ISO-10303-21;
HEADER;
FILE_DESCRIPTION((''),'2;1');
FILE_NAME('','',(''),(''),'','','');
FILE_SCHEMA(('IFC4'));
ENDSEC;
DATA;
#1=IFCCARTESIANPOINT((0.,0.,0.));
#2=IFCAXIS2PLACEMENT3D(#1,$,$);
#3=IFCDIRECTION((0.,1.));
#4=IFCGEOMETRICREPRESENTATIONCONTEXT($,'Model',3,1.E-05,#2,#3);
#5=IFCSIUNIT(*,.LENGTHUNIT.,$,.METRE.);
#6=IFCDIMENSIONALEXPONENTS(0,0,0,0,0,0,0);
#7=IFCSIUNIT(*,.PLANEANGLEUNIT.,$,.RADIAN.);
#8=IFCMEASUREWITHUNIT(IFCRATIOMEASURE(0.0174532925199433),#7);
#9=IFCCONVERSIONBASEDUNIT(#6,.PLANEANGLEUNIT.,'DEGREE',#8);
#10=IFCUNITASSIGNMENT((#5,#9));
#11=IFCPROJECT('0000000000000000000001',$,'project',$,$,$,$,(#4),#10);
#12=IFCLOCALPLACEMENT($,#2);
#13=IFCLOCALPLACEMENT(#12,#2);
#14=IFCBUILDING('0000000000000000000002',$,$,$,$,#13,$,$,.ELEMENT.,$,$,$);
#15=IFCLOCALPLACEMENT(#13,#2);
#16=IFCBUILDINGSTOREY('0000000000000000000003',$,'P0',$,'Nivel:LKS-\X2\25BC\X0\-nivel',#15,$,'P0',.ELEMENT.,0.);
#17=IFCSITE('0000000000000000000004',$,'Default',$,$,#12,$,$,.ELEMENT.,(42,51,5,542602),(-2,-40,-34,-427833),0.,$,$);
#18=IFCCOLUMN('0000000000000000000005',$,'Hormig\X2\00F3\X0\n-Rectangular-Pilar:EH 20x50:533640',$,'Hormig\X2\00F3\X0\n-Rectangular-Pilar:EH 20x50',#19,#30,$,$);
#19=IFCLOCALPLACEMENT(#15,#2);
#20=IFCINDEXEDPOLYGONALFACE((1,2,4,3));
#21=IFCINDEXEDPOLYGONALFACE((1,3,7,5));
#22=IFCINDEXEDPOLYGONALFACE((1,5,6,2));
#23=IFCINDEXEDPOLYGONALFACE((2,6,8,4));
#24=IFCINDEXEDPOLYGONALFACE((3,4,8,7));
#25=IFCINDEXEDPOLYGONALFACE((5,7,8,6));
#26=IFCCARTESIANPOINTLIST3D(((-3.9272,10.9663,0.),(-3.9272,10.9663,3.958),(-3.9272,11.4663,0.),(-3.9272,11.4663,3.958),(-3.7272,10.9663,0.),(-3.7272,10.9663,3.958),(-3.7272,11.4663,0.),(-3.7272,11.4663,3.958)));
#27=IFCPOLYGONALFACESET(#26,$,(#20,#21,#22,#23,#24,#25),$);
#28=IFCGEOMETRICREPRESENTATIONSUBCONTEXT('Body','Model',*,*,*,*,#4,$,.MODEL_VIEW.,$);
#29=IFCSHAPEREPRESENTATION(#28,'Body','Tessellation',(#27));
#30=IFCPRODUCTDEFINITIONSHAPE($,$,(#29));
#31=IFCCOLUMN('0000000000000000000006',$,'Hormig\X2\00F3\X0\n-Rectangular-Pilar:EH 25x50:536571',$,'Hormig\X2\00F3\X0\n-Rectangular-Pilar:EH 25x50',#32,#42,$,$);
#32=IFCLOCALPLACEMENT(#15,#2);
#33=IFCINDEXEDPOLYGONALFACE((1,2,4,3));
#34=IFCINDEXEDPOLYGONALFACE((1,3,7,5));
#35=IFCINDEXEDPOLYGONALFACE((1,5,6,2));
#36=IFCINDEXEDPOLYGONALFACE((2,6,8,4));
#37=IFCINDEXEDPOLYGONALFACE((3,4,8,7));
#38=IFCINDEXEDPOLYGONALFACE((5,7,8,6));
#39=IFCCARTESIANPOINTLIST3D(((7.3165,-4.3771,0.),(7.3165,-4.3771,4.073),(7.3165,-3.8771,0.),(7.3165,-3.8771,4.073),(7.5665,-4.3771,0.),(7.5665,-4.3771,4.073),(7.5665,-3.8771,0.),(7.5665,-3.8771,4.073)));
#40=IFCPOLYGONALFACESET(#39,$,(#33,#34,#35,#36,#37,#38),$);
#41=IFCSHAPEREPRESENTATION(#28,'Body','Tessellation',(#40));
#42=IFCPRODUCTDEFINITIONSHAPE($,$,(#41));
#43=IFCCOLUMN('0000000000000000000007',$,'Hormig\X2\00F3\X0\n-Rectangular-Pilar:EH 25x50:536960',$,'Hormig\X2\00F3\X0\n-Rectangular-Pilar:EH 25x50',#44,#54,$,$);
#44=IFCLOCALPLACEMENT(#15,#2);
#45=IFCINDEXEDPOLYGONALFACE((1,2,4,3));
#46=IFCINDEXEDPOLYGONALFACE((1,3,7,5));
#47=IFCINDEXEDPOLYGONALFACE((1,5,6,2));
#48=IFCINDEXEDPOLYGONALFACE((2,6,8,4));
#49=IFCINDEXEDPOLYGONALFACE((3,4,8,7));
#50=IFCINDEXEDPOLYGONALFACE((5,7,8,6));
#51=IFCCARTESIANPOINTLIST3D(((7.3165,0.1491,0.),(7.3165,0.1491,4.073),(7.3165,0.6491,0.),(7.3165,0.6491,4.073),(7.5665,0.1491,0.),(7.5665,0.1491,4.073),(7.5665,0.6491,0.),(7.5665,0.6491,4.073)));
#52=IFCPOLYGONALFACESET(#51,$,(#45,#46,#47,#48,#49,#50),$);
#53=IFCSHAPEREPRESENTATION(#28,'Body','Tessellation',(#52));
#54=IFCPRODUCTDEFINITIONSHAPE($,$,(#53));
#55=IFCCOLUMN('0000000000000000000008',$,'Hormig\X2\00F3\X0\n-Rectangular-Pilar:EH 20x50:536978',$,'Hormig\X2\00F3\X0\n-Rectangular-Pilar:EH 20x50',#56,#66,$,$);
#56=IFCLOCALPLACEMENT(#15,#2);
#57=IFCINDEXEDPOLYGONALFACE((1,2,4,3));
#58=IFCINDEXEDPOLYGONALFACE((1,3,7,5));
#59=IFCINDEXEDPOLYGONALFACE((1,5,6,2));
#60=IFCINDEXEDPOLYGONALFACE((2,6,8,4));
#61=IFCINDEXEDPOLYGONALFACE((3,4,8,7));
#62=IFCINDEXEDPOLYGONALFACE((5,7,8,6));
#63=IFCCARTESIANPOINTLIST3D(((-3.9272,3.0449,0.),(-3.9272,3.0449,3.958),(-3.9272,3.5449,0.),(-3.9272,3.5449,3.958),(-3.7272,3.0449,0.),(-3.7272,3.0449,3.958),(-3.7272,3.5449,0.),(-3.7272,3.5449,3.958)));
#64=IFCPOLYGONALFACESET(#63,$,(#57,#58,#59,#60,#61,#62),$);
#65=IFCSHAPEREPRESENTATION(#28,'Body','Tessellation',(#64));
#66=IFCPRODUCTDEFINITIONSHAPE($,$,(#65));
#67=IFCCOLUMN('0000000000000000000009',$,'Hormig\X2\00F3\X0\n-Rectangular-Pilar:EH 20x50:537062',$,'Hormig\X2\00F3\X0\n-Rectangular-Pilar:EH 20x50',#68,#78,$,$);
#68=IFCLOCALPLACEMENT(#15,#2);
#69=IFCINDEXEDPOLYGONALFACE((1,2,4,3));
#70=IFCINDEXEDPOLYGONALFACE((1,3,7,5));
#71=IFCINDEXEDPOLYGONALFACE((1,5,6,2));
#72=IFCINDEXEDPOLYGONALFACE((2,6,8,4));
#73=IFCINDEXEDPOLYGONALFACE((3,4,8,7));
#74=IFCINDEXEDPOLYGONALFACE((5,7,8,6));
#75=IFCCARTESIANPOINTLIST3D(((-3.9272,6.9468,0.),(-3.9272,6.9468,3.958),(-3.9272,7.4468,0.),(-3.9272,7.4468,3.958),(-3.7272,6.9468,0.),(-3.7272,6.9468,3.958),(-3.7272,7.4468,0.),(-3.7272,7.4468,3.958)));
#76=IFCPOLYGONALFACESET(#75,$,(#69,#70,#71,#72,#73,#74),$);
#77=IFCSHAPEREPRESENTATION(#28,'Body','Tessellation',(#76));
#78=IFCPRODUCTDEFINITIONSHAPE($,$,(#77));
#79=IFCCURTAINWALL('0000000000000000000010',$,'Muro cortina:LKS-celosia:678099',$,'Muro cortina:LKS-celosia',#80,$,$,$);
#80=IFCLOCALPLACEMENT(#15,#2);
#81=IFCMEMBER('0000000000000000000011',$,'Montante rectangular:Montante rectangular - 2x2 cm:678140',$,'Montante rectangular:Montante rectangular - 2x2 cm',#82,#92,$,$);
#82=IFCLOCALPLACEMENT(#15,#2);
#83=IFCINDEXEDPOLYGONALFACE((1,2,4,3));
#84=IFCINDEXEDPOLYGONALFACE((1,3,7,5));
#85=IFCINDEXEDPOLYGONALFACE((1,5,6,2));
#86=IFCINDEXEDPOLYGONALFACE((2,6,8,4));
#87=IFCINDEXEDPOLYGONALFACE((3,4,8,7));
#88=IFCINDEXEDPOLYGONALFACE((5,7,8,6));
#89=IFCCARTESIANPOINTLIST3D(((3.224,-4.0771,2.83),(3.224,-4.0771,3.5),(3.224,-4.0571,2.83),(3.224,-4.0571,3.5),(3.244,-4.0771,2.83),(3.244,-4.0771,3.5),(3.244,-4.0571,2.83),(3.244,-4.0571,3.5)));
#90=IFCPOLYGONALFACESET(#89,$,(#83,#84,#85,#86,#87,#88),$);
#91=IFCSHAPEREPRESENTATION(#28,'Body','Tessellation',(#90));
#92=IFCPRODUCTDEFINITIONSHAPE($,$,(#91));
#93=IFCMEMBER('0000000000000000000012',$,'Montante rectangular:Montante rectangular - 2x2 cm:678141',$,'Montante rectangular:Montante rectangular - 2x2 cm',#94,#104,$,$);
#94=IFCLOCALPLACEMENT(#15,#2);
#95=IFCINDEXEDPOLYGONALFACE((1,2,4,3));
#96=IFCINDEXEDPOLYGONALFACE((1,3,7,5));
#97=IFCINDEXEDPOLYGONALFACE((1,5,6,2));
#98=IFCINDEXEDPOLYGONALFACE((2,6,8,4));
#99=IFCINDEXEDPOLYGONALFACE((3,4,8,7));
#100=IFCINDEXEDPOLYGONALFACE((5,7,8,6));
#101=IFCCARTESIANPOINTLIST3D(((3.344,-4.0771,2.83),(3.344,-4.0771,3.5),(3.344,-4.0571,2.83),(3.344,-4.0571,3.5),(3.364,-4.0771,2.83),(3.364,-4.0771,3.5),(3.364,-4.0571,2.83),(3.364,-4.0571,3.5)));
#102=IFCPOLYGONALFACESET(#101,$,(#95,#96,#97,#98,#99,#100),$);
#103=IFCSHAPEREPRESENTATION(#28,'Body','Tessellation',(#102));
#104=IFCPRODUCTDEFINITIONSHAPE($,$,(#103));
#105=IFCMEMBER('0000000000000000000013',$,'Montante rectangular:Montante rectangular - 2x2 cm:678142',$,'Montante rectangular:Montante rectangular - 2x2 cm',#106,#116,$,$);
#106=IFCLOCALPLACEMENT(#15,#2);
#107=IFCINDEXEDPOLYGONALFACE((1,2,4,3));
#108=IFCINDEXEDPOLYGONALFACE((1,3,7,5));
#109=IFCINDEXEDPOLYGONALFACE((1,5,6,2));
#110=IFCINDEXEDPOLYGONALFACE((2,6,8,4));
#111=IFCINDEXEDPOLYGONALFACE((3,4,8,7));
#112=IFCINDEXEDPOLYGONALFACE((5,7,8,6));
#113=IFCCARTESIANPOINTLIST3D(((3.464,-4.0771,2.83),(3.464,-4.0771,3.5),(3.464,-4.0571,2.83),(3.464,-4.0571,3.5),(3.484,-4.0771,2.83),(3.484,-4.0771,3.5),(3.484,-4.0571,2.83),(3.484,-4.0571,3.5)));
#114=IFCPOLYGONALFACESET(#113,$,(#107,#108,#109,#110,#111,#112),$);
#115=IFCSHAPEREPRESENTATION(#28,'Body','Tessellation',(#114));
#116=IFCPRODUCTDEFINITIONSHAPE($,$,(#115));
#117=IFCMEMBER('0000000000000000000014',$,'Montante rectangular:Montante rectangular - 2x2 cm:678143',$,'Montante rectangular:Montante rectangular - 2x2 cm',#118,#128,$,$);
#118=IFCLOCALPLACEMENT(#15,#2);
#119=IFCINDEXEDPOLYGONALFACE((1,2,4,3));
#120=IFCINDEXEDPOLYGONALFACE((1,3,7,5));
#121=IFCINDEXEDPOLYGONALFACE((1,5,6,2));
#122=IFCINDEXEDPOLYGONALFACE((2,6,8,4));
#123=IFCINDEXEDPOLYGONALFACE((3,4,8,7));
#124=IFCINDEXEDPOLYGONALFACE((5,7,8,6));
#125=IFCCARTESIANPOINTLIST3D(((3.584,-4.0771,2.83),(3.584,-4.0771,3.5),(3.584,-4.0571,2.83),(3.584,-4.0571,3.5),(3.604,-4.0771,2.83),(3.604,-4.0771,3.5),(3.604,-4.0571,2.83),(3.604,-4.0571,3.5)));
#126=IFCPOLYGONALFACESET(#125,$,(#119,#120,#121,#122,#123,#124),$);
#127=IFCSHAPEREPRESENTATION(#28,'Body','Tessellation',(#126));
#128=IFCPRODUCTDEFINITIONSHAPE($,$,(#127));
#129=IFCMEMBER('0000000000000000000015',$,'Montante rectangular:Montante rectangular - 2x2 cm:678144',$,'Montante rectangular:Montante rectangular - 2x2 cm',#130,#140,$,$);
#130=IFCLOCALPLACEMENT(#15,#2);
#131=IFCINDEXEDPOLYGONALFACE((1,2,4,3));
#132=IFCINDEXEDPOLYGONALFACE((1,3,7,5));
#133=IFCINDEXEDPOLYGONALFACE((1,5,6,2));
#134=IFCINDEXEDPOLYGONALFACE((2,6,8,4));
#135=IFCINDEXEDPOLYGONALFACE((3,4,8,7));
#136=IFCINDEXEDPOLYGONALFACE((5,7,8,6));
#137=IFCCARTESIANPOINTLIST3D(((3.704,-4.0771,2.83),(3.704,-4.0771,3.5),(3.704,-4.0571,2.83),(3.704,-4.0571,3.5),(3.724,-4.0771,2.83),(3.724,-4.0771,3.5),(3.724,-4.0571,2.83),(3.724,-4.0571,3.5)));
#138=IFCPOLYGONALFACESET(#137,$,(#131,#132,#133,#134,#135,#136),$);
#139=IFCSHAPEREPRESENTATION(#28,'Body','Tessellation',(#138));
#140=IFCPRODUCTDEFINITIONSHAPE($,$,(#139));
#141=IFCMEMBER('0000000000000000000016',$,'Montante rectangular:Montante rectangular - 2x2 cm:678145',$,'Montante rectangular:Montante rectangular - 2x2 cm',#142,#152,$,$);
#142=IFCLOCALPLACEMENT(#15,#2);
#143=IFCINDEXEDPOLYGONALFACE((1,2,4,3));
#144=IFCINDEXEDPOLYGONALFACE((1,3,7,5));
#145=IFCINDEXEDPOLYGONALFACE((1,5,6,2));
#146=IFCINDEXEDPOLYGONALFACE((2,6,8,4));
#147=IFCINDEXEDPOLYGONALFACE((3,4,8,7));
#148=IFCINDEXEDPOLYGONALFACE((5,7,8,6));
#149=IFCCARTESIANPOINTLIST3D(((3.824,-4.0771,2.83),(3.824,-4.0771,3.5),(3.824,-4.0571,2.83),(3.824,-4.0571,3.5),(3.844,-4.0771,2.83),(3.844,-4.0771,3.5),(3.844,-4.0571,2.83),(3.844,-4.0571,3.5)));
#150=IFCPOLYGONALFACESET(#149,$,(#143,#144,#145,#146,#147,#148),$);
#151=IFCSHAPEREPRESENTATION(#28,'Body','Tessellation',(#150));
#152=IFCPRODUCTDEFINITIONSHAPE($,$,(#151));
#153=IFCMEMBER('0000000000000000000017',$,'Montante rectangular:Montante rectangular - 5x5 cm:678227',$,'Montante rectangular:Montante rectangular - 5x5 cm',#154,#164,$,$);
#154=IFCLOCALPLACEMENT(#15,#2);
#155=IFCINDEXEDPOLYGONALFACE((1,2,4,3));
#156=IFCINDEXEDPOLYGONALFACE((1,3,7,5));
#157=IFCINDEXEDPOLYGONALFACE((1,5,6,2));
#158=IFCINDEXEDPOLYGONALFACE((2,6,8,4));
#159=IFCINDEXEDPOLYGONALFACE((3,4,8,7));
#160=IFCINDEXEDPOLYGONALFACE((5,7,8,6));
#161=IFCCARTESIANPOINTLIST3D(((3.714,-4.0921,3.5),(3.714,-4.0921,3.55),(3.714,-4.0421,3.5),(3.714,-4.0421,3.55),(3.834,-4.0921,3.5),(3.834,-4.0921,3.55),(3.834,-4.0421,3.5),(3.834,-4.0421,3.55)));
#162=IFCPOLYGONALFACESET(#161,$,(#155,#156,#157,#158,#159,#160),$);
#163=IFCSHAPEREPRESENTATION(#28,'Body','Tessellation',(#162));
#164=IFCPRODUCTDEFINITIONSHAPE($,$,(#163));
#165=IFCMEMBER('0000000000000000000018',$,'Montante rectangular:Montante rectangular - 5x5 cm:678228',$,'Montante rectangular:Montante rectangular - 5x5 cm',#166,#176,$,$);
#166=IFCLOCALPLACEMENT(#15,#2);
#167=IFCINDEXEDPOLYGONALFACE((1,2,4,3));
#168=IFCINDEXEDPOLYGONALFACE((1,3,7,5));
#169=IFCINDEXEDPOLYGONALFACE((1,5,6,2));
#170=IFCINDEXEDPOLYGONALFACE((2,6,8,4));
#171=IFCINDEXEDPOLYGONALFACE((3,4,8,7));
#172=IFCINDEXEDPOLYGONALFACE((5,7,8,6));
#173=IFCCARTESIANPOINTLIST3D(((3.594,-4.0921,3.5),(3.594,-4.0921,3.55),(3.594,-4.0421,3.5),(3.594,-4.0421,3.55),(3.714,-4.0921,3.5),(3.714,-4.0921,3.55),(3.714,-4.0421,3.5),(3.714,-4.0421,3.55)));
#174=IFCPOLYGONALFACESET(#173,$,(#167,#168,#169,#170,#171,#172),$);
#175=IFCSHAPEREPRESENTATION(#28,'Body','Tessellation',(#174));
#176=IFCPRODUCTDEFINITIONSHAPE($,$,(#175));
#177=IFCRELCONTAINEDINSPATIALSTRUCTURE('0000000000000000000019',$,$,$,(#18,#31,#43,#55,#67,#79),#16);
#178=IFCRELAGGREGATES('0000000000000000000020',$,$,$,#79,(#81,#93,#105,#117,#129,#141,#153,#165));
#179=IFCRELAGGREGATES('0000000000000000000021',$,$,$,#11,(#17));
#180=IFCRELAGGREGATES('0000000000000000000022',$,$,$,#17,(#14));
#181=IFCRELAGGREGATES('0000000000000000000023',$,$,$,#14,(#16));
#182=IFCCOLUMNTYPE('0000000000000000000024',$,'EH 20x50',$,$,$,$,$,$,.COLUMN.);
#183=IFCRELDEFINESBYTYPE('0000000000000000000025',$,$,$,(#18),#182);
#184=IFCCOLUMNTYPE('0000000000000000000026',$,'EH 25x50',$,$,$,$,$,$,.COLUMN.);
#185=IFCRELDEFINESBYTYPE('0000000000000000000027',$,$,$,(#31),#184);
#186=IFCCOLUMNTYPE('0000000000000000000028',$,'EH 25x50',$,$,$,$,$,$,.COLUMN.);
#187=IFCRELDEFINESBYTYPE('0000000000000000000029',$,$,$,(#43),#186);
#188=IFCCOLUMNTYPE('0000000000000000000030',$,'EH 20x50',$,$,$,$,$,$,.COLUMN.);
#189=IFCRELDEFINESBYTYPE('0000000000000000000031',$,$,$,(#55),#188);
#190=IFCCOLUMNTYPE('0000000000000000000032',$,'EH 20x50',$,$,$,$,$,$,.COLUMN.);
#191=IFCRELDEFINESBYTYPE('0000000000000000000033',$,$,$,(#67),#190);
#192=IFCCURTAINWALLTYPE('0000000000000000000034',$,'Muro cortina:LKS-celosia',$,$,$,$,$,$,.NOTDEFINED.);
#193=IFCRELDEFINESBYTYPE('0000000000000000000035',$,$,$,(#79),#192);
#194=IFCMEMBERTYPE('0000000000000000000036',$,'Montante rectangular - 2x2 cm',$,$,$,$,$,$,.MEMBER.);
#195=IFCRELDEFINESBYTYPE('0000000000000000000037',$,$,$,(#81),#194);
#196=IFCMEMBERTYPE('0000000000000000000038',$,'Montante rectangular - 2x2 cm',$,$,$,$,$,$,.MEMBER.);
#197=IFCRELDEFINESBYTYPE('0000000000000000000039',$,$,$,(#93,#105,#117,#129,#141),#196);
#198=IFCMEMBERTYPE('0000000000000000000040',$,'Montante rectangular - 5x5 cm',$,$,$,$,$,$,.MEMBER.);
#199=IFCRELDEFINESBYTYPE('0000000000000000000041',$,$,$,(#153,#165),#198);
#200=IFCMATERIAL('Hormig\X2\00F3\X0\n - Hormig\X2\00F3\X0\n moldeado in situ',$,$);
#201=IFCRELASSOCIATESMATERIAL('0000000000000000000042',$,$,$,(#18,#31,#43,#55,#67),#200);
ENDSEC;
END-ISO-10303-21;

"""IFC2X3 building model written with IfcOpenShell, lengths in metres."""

from ifc_helpers import new_model, entity, si_unit, converted_unit, direction, frame, origin, origin_2d_with_axis, place, context, subcontext, project, spatial, rectangle, extrude, source, transform, mapped, material, type_object, type_shapes, element, aggregate, save


model = new_model("IFC2X3")

# Units and contexts
model_context = context("Model", 3, precision=1e-05, world=origin(), true_north=direction((0.0, 1.0)))
body_context = subcontext(model_context, "Body", "Model", "MODEL_VIEW")
ifc_project = project(units=[si_unit("LENGTHUNIT", "METRE"), converted_unit("PLANEANGLEUNIT", "DEGREE", entity("IfcRatioMeasure", 0.0174532925199433), si_unit("PLANEANGLEUNIT", "RADIAN"), dimensions=[0, 0, 0, 0, 0, 0, 0])], contexts=[model_context])

# Site, building, storey
site_placement = place(None, origin())
site = spatial("IfcSite", under=ifc_project, at=site_placement, Name="Default", CompositionType="ELEMENT", RefLatitude=(42, 51, 5, 542602), RefLongitude=(-2, -40, -34, -427833), RefElevation=0.0)
building_placement = place(site_placement, origin())
building = spatial("IfcBuilding", under=site, at=building_placement, CompositionType="ELEMENT")
storey_placement = place(building_placement, origin())
storey = spatial("IfcBuildingStorey", under=building, at=storey_placement, Name="P0", ObjectType="Nivel:LKS-▼-nivel", LongName="P0", CompositionType="ELEMENT", Elevation=0.0)

# Columns
ifc_material_1 = material(Name="Hormigón - Hormigón moldeado in situ")
column_type_1 = type_object("IfcColumnType", Name="EH 20x50", PredefinedType="COLUMN")
shared_shape_1 = source(origin(), body_context, "Body", "SweptSolid", [
    extrude(rectangle(XDim=0.5, YDim=0.2, at=origin_2d_with_axis()), frame((-3.8272, 11.2163, 0.0), z_axis=(0.0, 0.0, 1.0), x_axis=(0.0, -1.0, 0.0)), (0.0, 0.0, 1.0), 3.958),
])
type_shapes(column_type_1, [shared_shape_1])
column_1_placement = place(storey_placement, origin())
element("IfcColumn", 1, at=column_1_placement, inside=storey, type_object=column_type_1, material=ifc_material_1, Name="Hormigón-Rectangular-Pilar:EH 20x50:533640", ObjectType="Hormigón-Rectangular-Pilar:EH 20x50", context=body_context, shape_type="MappedRepresentation", body=[
    mapped(shared_shape_1, transform((0.0, 0.0, 0.0), scale=1.0)),
])
column_type_2 = type_object("IfcColumnType", Name="EH 25x50", PredefinedType="COLUMN")
shared_shape_2 = source(origin(), body_context, "Body", "SweptSolid", [
    extrude(rectangle(XDim=0.5, YDim=0.25, at=origin_2d_with_axis()), frame((7.4415, -4.1271, 0.0), z_axis=(0.0, 0.0, 1.0), x_axis=(0.0, -1.0, 0.0)), (0.0, 0.0, 1.0), 4.073),
])
type_shapes(column_type_2, [shared_shape_2])
column_2_placement = place(storey_placement, origin())
element("IfcColumn", 2, at=column_2_placement, inside=storey, type_object=column_type_2, material=ifc_material_1, Name="Hormigón-Rectangular-Pilar:EH 25x50:536571", ObjectType="Hormigón-Rectangular-Pilar:EH 25x50", context=body_context, shape_type="MappedRepresentation", body=[
    mapped(shared_shape_2, transform((0.0, 0.0, 0.0), scale=1.0)),
])
column_type_3 = type_object("IfcColumnType", Name="EH 25x50", PredefinedType="COLUMN")
shared_shape_3 = source(origin(), body_context, "Body", "SweptSolid", [
    extrude(rectangle(XDim=0.5, YDim=0.25, at=origin_2d_with_axis()), frame((7.4415, 0.3991, 0.0), z_axis=(0.0, 0.0, 1.0), x_axis=(0.0, -1.0, 0.0)), (0.0, 0.0, 1.0), 4.073),
])
type_shapes(column_type_3, [shared_shape_3])
column_3_placement = place(storey_placement, origin())
element("IfcColumn", 3, at=column_3_placement, inside=storey, type_object=column_type_3, material=ifc_material_1, Name="Hormigón-Rectangular-Pilar:EH 25x50:536960", ObjectType="Hormigón-Rectangular-Pilar:EH 25x50", context=body_context, shape_type="MappedRepresentation", body=[
    mapped(shared_shape_3, transform((0.0, 0.0, 0.0), scale=1.0)),
])
column_type_4 = type_object("IfcColumnType", Name="EH 20x50", PredefinedType="COLUMN")
shared_shape_4 = source(origin(), body_context, "Body", "SweptSolid", [
    extrude(rectangle(XDim=0.5, YDim=0.2, at=origin_2d_with_axis()), frame((-3.8272, 3.2949, 0.0), z_axis=(0.0, 0.0, 1.0), x_axis=(0.0, -1.0, 0.0)), (0.0, 0.0, 1.0), 3.958),
])
type_shapes(column_type_4, [shared_shape_4])
column_4_placement = place(storey_placement, origin())
element("IfcColumn", 4, at=column_4_placement, inside=storey, type_object=column_type_4, material=ifc_material_1, Name="Hormigón-Rectangular-Pilar:EH 20x50:536978", ObjectType="Hormigón-Rectangular-Pilar:EH 20x50", context=body_context, shape_type="MappedRepresentation", body=[
    mapped(shared_shape_4, transform((0.0, 0.0, 0.0), scale=1.0)),
])
column_type_5 = type_object("IfcColumnType", Name="EH 20x50", PredefinedType="COLUMN")
shared_shape_5 = source(origin(), body_context, "Body", "SweptSolid", [
    extrude(rectangle(XDim=0.5, YDim=0.2, at=origin_2d_with_axis()), frame((-3.8272, 7.1968, 0.0), z_axis=(0.0, 0.0, 1.0), x_axis=(0.0, -1.0, 0.0)), (0.0, 0.0, 1.0), 3.958),
])
type_shapes(column_type_5, [shared_shape_5])
column_5_placement = place(storey_placement, origin())
element("IfcColumn", 5, at=column_5_placement, inside=storey, type_object=column_type_5, material=ifc_material_1, Name="Hormigón-Rectangular-Pilar:EH 20x50:537062", ObjectType="Hormigón-Rectangular-Pilar:EH 20x50", context=body_context, shape_type="MappedRepresentation", body=[
    mapped(shared_shape_5, transform((0.0, 0.0, 0.0), scale=1.0)),
])

# Curtain wall, members
curtain_wall_type = type_object("IfcCurtainWallType", Name="Muro cortina:LKS-celosia", PredefinedType="NOTDEFINED")
curtain_wall_placement = place(storey_placement, origin())
curtain_wall = element("IfcCurtainWall", 6, at=curtain_wall_placement, inside=storey, type_object=curtain_wall_type, Name="Muro cortina:LKS-celosia:678099", ObjectType="Muro cortina:LKS-celosia")
member_type_1 = type_object("IfcMemberType", Name="Montante rectangular - 2x2 cm", PredefinedType="MEMBER")
shared_shape_6 = source(origin(), body_context, "Body", "SweptSolid", [
    extrude(rectangle(XDim=0.02, YDim=0.02, at=origin_2d_with_axis()), frame((-0.01, -0.1, -0.67), z_axis=(0.0, 0.0, 1.0), x_axis=(0.0, -1.0, 0.0)), (0.0, 0.0, 1.0), 0.67),
])
type_shapes(member_type_1, [shared_shape_6])
member_1_placement = place(storey_placement, frame((3.224, -4.1671, 3.5), z_axis=(0.0, 0.0, 1.0), x_axis=(-1.0, 0.0, 0.0)))
member_1 = element("IfcMember", 7, at=member_1_placement, type_object=member_type_1, Name="Montante rectangular:Montante rectangular - 2x2 cm:678140", ObjectType="Montante rectangular:Montante rectangular - 2x2 cm", context=body_context, shape_type="MappedRepresentation", body=[
    mapped(shared_shape_6, transform((0.0, 0.0, 0.0), scale=1.0)),
])
member_type_2 = type_object("IfcMemberType", Name="Montante rectangular - 2x2 cm", PredefinedType="MEMBER")
shared_shape_7 = source(origin(), body_context, "Body", "SweptSolid", [
    extrude(rectangle(XDim=0.02, YDim=0.02, at=origin_2d_with_axis()), frame((0.0, -0.1, -0.67), z_axis=(0.0, 0.0, 1.0), x_axis=(0.0, -1.0, 0.0)), (0.0, 0.0, 1.0), 0.67),
])
type_shapes(member_type_2, [shared_shape_7])
member_2_placement = place(storey_placement, frame((3.354, -4.1671, 2.83), z_axis=(0.0, 0.0, -1.0), x_axis=(1.0, 0.0, 0.0)))
member_2 = element("IfcMember", 8, at=member_2_placement, type_object=member_type_2, Name="Montante rectangular:Montante rectangular - 2x2 cm:678141", ObjectType="Montante rectangular:Montante rectangular - 2x2 cm", context=body_context, shape_type="MappedRepresentation", body=[
    mapped(shared_shape_7, transform((0.0, 0.0, 0.0), scale=1.0)),
])
member_3_placement = place(storey_placement, frame((3.474, -4.1671, 2.83), z_axis=(0.0, 0.0, -1.0), x_axis=(1.0, 0.0, 0.0)))
member_3 = element("IfcMember", 9, at=member_3_placement, type_object=member_type_2, Name="Montante rectangular:Montante rectangular - 2x2 cm:678142", ObjectType="Montante rectangular:Montante rectangular - 2x2 cm", context=body_context, shape_type="MappedRepresentation", body=[
    mapped(shared_shape_7, transform((0.0, 0.0, 0.0), scale=1.0)),
])
member_4_placement = place(storey_placement, frame((3.594, -4.1671, 2.83), z_axis=(0.0, 0.0, -1.0), x_axis=(1.0, 0.0, 0.0)))
member_4 = element("IfcMember", 10, at=member_4_placement, type_object=member_type_2, Name="Montante rectangular:Montante rectangular - 2x2 cm:678143", ObjectType="Montante rectangular:Montante rectangular - 2x2 cm", context=body_context, shape_type="MappedRepresentation", body=[
    mapped(shared_shape_7, transform((0.0, 0.0, 0.0), scale=1.0)),
])
member_5_placement = place(storey_placement, frame((3.714, -4.1671, 2.83), z_axis=(0.0, 0.0, -1.0), x_axis=(1.0, 0.0, 0.0)))
member_5 = element("IfcMember", 11, at=member_5_placement, type_object=member_type_2, Name="Montante rectangular:Montante rectangular - 2x2 cm:678144", ObjectType="Montante rectangular:Montante rectangular - 2x2 cm", context=body_context, shape_type="MappedRepresentation", body=[
    mapped(shared_shape_7, transform((0.0, 0.0, 0.0), scale=1.0)),
])
member_6_placement = place(storey_placement, frame((3.834, -4.1671, 2.83), z_axis=(0.0, 0.0, -1.0), x_axis=(1.0, 0.0, 0.0)))
member_6 = element("IfcMember", 12, at=member_6_placement, type_object=member_type_2, Name="Montante rectangular:Montante rectangular - 2x2 cm:678145", ObjectType="Montante rectangular:Montante rectangular - 2x2 cm", context=body_context, shape_type="MappedRepresentation", body=[
    mapped(shared_shape_7, transform((0.0, 0.0, 0.0), scale=1.0)),
])
member_type_3 = type_object("IfcMemberType", Name="Montante rectangular - 5x5 cm", PredefinedType="MEMBER")
shared_shape_8 = source(origin(), body_context, "Body", "SweptSolid", [
    extrude(rectangle(XDim=0.05, YDim=0.05, at=origin_2d_with_axis()), frame((-0.025, -0.1, -0.12), z_axis=(0.0, 0.0, 1.0), x_axis=(0.0, -1.0, 0.0)), (0.0, 0.0, 1.0), 0.12),
])
type_shapes(member_type_3, [shared_shape_8])
member_7_placement = place(storey_placement, frame((3.834, -4.1671, 3.55), z_axis=(1.0, 0.0, 0.0), x_axis=(0.0, 0.0, 1.0)))
member_7 = element("IfcMember", 13, at=member_7_placement, type_object=member_type_3, Name="Montante rectangular:Montante rectangular - 5x5 cm:678227", ObjectType="Montante rectangular:Montante rectangular - 5x5 cm", context=body_context, shape_type="MappedRepresentation", body=[
    mapped(shared_shape_8, transform((0.0, 0.0, 0.0), scale=1.0)),
])
member_8_placement = place(storey_placement, frame((3.714, -4.1671, 3.55), z_axis=(1.0, 0.0, 0.0), x_axis=(0.0, 0.0, 1.0)))
member_8 = element("IfcMember", 14, at=member_8_placement, type_object=member_type_3, Name="Montante rectangular:Montante rectangular - 5x5 cm:678228", ObjectType="Montante rectangular:Montante rectangular - 5x5 cm", context=body_context, shape_type="MappedRepresentation", body=[
    mapped(shared_shape_8, transform((0.0, 0.0, 0.0), scale=1.0)),
])
aggregate(curtain_wall, [member_1, member_2, member_3, member_4, member_5, member_6, member_7, member_8])

save(model, "model.ifc")
